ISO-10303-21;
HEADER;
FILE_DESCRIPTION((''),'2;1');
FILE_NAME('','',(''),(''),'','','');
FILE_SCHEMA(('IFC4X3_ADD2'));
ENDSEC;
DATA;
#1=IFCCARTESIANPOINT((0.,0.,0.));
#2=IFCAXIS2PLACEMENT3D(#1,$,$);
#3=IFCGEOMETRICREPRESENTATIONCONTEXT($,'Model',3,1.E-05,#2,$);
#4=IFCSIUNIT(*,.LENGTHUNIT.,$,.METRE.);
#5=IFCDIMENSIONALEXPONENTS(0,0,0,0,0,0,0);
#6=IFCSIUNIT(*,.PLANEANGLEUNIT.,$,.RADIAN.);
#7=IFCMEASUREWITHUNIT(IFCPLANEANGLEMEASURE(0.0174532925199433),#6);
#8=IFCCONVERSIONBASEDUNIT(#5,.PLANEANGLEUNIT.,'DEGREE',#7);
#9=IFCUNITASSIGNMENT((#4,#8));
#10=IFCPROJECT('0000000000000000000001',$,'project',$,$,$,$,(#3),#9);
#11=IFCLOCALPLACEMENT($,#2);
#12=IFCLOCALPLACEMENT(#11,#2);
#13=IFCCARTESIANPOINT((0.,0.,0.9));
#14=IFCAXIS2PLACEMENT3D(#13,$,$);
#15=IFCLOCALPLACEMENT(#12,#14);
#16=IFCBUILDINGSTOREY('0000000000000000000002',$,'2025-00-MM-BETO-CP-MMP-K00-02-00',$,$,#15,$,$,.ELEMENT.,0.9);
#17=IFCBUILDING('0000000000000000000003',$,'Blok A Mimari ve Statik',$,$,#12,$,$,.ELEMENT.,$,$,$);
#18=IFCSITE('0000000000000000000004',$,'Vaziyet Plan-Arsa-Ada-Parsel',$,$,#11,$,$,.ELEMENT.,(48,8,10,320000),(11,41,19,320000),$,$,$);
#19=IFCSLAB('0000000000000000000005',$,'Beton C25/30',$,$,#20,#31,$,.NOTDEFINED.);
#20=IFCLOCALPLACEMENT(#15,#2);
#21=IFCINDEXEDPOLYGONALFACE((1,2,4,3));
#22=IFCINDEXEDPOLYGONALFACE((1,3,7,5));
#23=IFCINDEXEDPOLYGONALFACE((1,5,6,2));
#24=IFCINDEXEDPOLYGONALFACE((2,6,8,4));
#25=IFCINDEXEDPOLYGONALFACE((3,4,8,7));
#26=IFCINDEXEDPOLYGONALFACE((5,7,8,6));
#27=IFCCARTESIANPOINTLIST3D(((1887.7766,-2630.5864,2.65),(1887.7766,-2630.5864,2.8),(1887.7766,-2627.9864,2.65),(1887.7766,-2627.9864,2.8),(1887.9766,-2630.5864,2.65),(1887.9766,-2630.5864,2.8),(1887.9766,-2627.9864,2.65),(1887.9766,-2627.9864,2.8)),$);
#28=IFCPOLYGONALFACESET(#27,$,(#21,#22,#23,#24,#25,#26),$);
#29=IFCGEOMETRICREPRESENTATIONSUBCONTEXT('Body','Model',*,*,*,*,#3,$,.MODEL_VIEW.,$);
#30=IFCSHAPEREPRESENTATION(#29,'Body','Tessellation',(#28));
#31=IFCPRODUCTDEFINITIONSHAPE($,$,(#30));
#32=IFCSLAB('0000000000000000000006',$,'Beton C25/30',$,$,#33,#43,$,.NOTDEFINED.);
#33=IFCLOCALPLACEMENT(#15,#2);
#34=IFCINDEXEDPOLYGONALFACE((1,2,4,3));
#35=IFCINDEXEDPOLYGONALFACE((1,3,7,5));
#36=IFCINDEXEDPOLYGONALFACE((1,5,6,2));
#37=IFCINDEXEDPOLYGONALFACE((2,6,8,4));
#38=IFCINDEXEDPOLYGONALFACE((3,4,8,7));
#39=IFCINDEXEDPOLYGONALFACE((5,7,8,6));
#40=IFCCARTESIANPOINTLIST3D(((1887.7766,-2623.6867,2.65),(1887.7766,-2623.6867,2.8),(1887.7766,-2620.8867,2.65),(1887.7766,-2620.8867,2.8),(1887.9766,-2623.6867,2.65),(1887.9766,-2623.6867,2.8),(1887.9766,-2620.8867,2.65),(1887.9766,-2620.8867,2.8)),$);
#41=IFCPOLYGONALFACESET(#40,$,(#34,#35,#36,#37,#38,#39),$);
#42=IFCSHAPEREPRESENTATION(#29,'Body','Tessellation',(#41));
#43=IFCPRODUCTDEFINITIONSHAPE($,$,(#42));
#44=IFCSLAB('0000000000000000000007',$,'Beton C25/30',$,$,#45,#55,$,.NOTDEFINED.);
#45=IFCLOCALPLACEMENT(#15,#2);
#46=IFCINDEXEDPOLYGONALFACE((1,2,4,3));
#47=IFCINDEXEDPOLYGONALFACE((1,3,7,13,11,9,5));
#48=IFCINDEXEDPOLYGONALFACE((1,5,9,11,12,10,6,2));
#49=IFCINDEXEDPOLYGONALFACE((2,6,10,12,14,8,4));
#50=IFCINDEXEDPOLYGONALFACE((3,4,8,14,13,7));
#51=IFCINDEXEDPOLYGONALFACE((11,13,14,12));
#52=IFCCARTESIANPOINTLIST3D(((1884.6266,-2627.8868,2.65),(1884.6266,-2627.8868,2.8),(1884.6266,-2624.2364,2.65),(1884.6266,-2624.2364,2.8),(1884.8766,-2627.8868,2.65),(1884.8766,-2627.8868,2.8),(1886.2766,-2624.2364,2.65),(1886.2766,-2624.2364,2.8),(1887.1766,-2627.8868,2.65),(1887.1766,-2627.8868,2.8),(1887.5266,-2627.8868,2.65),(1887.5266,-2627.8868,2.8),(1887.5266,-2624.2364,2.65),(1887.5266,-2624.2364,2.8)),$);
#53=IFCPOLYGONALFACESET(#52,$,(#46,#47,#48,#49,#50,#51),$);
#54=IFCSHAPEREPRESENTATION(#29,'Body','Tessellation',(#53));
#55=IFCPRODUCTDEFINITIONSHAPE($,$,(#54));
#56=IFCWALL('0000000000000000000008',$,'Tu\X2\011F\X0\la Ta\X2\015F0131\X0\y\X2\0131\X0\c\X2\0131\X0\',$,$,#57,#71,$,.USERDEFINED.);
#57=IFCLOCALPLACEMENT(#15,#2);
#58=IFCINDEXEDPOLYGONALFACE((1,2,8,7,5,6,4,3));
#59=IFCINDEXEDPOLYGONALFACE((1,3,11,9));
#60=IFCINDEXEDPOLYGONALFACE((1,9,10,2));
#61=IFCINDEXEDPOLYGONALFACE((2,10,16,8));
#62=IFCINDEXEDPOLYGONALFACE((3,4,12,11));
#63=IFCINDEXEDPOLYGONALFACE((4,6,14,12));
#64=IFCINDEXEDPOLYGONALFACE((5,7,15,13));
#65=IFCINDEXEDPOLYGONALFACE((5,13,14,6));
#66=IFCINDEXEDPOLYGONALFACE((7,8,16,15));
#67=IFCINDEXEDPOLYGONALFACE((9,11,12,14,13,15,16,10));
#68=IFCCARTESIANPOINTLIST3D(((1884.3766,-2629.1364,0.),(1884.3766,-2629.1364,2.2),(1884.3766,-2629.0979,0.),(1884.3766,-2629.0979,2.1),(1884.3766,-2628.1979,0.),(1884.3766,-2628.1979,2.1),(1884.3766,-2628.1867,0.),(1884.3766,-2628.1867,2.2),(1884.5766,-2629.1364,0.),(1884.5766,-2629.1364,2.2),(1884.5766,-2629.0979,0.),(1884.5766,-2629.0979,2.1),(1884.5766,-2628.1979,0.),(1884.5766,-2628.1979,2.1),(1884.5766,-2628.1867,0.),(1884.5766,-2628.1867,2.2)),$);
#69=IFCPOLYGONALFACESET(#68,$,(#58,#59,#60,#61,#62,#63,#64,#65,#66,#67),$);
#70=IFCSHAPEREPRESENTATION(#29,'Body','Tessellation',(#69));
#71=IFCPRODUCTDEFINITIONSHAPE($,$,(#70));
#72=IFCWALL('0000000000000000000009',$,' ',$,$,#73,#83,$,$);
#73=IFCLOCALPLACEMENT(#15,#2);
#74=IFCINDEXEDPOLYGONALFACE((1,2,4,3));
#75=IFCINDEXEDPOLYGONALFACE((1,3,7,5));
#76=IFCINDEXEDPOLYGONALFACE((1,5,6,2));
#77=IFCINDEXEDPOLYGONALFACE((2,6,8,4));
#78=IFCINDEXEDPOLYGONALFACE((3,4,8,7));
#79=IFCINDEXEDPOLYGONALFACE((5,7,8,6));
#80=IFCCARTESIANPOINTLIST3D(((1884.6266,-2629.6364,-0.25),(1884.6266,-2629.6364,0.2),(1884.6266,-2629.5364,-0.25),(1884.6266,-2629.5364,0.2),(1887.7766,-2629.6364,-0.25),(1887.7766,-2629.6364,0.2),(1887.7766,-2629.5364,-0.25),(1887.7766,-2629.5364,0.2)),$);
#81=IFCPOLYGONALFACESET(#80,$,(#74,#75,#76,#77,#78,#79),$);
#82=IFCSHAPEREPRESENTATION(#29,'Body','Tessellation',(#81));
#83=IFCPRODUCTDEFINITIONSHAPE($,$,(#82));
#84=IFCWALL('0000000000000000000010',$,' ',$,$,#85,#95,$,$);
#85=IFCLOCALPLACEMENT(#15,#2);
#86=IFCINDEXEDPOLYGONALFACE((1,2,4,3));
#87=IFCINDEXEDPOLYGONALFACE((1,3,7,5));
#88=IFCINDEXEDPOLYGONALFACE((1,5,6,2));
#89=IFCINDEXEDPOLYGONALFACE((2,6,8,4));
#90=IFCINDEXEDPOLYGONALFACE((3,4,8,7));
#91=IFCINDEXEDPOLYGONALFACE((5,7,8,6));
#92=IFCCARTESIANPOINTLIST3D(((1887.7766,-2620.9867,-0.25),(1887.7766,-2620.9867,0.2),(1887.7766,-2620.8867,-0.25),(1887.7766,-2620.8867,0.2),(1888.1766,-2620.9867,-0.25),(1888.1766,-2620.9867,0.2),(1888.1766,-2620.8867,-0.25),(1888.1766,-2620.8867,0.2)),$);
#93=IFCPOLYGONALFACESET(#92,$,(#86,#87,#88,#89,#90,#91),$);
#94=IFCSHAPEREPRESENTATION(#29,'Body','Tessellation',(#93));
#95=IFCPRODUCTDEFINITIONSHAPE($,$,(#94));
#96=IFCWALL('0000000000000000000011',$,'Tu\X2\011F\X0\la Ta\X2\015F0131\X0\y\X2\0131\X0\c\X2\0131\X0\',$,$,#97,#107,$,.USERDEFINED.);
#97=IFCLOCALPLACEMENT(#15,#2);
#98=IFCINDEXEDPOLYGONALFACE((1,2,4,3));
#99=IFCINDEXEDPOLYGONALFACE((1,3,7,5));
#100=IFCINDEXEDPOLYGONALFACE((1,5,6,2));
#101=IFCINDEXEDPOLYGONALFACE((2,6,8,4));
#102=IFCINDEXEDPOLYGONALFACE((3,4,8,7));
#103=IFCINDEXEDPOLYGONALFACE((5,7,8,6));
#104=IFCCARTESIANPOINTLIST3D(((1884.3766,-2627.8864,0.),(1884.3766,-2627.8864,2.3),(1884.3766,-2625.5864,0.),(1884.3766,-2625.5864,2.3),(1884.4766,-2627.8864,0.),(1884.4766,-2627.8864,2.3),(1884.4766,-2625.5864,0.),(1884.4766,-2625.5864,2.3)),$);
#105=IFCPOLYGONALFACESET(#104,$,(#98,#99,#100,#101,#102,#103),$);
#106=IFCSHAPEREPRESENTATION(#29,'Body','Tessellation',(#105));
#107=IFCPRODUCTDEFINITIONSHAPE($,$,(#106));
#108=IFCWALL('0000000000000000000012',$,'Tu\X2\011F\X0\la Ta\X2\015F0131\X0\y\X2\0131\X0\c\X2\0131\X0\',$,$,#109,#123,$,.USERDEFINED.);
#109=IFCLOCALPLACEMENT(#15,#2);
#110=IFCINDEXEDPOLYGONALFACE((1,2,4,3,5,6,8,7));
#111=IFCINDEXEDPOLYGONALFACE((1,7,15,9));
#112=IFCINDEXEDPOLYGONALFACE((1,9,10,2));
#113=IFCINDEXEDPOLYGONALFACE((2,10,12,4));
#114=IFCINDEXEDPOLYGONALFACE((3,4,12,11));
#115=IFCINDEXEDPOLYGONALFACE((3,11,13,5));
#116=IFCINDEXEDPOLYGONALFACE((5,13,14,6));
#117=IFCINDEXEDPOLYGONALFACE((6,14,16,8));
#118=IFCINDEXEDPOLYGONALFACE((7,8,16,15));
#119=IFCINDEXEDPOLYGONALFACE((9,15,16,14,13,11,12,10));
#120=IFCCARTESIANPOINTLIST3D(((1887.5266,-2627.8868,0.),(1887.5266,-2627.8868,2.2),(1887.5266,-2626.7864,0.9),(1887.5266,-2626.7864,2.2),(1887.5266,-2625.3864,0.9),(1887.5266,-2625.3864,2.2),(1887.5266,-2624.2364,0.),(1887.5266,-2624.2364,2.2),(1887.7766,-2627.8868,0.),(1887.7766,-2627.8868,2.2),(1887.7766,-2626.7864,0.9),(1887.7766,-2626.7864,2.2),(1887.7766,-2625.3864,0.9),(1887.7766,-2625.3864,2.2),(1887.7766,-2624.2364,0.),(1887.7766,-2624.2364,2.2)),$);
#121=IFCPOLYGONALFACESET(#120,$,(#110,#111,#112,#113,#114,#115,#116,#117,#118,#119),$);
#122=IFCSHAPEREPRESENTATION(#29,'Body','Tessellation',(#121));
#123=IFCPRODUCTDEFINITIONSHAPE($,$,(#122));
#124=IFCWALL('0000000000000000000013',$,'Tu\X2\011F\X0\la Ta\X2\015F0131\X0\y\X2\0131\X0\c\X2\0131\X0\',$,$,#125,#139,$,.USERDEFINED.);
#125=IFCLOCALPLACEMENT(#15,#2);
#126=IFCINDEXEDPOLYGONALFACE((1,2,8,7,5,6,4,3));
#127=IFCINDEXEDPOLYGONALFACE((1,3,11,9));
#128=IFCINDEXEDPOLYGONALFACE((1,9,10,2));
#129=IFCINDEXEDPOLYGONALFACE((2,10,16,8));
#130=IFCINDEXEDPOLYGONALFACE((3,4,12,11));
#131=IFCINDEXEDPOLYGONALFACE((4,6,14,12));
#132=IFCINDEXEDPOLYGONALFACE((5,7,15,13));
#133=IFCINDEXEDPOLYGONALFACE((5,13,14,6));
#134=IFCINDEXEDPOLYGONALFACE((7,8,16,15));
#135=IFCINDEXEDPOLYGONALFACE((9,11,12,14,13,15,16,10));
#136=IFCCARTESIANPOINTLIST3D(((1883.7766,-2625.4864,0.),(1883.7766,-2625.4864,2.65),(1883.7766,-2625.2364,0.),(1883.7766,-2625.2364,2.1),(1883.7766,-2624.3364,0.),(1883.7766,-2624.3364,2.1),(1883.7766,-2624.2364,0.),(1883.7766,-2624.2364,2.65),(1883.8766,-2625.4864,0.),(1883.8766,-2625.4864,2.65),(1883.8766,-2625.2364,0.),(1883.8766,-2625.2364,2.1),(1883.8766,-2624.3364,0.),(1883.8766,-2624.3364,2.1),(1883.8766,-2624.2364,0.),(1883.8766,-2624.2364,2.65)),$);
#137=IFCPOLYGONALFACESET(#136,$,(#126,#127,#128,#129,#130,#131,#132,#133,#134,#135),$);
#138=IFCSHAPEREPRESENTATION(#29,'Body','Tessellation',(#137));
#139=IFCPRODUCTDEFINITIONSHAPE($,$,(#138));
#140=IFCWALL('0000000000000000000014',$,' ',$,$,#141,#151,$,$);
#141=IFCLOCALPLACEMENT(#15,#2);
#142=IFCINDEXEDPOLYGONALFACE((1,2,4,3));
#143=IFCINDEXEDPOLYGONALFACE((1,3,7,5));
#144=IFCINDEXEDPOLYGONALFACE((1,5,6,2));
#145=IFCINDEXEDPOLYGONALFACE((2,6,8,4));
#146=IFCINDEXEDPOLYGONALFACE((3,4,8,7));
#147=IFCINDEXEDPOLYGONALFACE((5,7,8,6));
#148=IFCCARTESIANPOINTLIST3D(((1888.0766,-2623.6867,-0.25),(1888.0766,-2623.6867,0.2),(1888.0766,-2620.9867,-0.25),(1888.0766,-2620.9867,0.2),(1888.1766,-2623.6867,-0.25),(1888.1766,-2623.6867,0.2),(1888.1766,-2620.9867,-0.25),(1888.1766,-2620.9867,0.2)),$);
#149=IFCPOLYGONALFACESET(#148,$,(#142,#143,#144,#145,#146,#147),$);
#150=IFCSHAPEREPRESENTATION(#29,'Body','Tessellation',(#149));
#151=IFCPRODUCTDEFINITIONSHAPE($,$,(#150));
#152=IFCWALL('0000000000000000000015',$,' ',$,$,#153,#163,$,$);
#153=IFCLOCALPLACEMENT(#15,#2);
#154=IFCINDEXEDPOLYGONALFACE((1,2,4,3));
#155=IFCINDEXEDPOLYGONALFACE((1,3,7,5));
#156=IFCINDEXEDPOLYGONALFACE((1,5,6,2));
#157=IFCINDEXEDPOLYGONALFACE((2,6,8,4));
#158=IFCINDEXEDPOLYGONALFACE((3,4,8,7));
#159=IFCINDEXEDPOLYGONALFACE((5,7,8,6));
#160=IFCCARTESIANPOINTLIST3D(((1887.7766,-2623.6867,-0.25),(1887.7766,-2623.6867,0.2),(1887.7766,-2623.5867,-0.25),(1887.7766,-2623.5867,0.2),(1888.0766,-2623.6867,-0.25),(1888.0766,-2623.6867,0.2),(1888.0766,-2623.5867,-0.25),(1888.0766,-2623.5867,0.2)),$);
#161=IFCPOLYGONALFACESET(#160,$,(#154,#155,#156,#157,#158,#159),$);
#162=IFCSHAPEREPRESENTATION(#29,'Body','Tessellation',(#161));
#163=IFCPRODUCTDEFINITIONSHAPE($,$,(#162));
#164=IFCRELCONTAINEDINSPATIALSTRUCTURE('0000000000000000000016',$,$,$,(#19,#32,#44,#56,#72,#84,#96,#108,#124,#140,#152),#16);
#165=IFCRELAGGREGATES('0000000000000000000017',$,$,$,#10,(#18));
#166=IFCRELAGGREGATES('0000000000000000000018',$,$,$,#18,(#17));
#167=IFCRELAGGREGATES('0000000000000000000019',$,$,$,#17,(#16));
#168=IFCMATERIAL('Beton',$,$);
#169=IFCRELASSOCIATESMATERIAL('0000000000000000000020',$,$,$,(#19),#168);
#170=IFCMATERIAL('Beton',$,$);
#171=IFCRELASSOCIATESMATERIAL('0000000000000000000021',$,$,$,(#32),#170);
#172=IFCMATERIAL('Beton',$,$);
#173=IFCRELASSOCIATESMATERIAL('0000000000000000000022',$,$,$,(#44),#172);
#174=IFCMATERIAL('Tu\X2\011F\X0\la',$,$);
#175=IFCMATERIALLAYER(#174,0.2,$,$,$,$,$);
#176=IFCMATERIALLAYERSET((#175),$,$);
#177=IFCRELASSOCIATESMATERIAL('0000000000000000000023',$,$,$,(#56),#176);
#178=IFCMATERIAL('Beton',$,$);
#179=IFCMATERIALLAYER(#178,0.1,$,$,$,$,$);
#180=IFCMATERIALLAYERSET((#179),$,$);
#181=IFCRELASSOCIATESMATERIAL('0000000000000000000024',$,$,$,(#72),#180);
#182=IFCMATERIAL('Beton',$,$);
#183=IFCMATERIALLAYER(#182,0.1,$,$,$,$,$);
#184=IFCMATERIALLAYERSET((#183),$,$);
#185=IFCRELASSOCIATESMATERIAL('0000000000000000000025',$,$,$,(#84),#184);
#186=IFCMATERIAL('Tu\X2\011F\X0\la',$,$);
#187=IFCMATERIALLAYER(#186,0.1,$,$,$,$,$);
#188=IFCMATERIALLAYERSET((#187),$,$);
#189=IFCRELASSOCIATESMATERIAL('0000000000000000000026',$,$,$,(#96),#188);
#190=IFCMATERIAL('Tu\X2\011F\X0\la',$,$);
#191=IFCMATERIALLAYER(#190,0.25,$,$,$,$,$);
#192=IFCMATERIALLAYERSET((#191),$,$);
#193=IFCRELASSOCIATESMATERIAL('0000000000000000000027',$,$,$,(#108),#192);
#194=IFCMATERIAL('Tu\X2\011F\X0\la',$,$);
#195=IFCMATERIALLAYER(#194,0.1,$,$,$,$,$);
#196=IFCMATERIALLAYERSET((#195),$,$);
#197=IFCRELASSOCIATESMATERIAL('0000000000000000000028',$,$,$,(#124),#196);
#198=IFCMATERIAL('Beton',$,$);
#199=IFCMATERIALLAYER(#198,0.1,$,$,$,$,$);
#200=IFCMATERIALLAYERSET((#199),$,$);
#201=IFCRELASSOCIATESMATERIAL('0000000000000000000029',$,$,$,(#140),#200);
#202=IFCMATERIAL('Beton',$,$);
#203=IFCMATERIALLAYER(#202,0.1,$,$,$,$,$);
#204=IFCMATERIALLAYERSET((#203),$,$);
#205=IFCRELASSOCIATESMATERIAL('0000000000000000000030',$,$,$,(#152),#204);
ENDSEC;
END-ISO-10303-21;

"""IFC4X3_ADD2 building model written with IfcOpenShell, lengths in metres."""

from ifc_helpers import new_model, entity, si_unit, converted_unit, frame, frame_2d, origin, origin_with_axes, place, context, subcontext, project, spatial, polyline, rectangle, outline, extrude, material, layer, layer_set, layer_usage, element, save


model = new_model("IFC4X3_ADD2")

# Units and contexts
model_context = context("Model", 3, precision=1e-05, world=origin())
body_context = subcontext(model_context, "Body", "Model", "MODEL_VIEW")
ifc_project = project(units=[si_unit("LENGTHUNIT", "METRE"), converted_unit("PLANEANGLEUNIT", "DEGREE", entity("IfcPlaneAngleMeasure", 0.0174532925199433), si_unit("PLANEANGLEUNIT", "RADIAN"), dimensions=[0, 0, 0, 0, 0, 0, 0])], contexts=[model_context])

# Site, building, storey
site_placement = place(None, origin())
site = spatial("IfcSite", under=ifc_project, at=site_placement, Name="Vaziyet Plan-Arsa-Ada-Parsel", CompositionType="ELEMENT", RefLatitude=(48, 8, 10, 320000), RefLongitude=(11, 41, 19, 320000))
building_placement = place(site_placement, origin())
building = spatial("IfcBuilding", under=site, at=building_placement, Name="Blok A Mimari ve Statik", CompositionType="ELEMENT")
storey_placement = place(building_placement, frame((0.0, 0.0, 0.9)))
storey = spatial("IfcBuildingStorey", under=building, at=storey_placement, Name="2025-00-MM-BETO-CP-MMP-K00-02-00", CompositionType="ELEMENT", Elevation=0.9)

# Slabs
ifc_material_1 = material(Name="Beton")
slab_1_placement = place(storey_placement, frame((1887.7766, -2630.5864, 2.65)))
element("IfcSlab", 1, at=slab_1_placement, inside=storey, material=ifc_material_1, Name="Beton C25/30", PredefinedType="NOTDEFINED", context=body_context, shape_type="SweptSolid", body=[
    extrude(rectangle(XDim=2.6, YDim=0.2, at=frame_2d((-0.1, 1.3), x_axis=(0.0, 1.0))), frame((0.2, 0.0, 0.0), z_axis=(0.0, 0.0, 1.0), x_axis=(1.0, 0.0, 0.0)), (0.0, 0.0, 1.0), 0.15),
])
ifc_material_2 = material(Name="Beton")
slab_2_placement = place(storey_placement, frame((1887.7766, -2623.6867, 2.65)))
element("IfcSlab", 2, at=slab_2_placement, inside=storey, material=ifc_material_2, Name="Beton C25/30", PredefinedType="NOTDEFINED", context=body_context, shape_type="SweptSolid", body=[
    extrude(rectangle(XDim=2.8, YDim=0.2, at=frame_2d((-0.1, 1.4), x_axis=(0.0, 1.0))), frame((0.2, 0.0, 0.0), z_axis=(0.0, 0.0, 1.0), x_axis=(1.0, 0.0, 0.0)), (0.0, 0.0, 1.0), 0.15),
])
ifc_material_3 = material(Name="Beton")
slab_3_placement = place(storey_placement, frame((1884.6266, -2627.8868, 2.65)))
element("IfcSlab", 3, at=slab_3_placement, inside=storey, material=ifc_material_3, Name="Beton C25/30", PredefinedType="NOTDEFINED", context=body_context, shape_type="SweptSolid", body=[
    extrude(outline(polyline([(0.0, 3.6503), (0.0, 0.0), (0.25, 0.0), (2.55, 0.0), (2.9, 0.0), (2.9, 3.6503), (1.65, 3.6503), (0.0, 3.6503)])), origin_with_axes(), (0.0, 0.0, 1.0), 0.15),
])

# Wall, opening
ifc_material_4 = material(Name="Tuğla")
ifc_layer_1 = layer(ifc_material_4, 0.2)
ifc_layer_set_1 = layer_set([ifc_layer_1])
ifc_layer_usage_1 = layer_usage(ifc_layer_set_1, "AXIS2", "POSITIVE", 0.0)
wall_1_placement = place(storey_placement, frame((1884.3766, -2628.1867, 0.0), z_axis=(0.0, 0.0, 1.0), x_axis=(0.0, -1.0, 0.0)))
wall_1 = element("IfcWall", 4, at=wall_1_placement, inside=storey, material=ifc_layer_usage_1, Name="Tuğla Taşıyıcı", PredefinedType="USERDEFINED", context=body_context, shape_type="SweptSolid", body=[
    extrude(rectangle(XDim=0.9497, YDim=0.2, at=frame_2d((0.4748, 0.1), x_axis=(1.0, 0.0))), origin_with_axes(), (0.0, 0.0, 1.0), 2.2),
])
opening_1_placement = place(wall_1_placement, frame((0.0111, 0.0, 0.0), z_axis=(0.0, 1.0, 0.0), x_axis=(0.0, 0.0, 1.0)))
element("IfcOpeningElement", 5, at=opening_1_placement, cuts=wall_1, PredefinedType="OPENING", context=body_context, shape_type="SweptSolid", body=[
    extrude(outline(polyline([(2.1, 0.9), (2.1, 0.0), (0.0, 0.0), (0.0, 0.9), (2.1, 0.9)])), origin_with_axes(), (0.0, 0.0, 1.0), 0.2),
])

# Walls
ifc_material_5 = material(Name="Beton")
ifc_layer_2 = layer(ifc_material_5, 0.1)
ifc_layer_set_2 = layer_set([ifc_layer_2])
ifc_layer_usage_2 = layer_usage(ifc_layer_set_2, "AXIS2", "POSITIVE", 0.0)
wall_2_placement = place(storey_placement, frame((1884.6266, -2629.6364, -0.25)))
element("IfcWall", 6, at=wall_2_placement, inside=storey, material=ifc_layer_usage_2, Name=" ", context=body_context, shape_type="SweptSolid", body=[
    extrude(rectangle(XDim=3.15, YDim=0.1, at=frame_2d((1.575, 0.05), x_axis=(1.0, 0.0))), origin_with_axes(), (0.0, 0.0, 1.0), 0.45),
])
ifc_material_6 = material(Name="Beton")
ifc_layer_3 = layer(ifc_material_6, 0.1)
ifc_layer_set_3 = layer_set([ifc_layer_3])
ifc_layer_usage_3 = layer_usage(ifc_layer_set_3, "AXIS2", "POSITIVE", 0.0)
wall_3_placement = place(storey_placement, frame((1888.1766, -2620.8867, -0.25), z_axis=(0.0, 0.0, 1.0), x_axis=(-1.0, 0.0, 0.0)))
element("IfcWall", 7, at=wall_3_placement, inside=storey, material=ifc_layer_usage_3, Name=" ", context=body_context, shape_type="SweptSolid", body=[
    extrude(rectangle(XDim=0.4, YDim=0.1, at=frame_2d((0.2, 0.05), x_axis=(1.0, 0.0))), origin_with_axes(), (0.0, 0.0, 1.0), 0.45),
])
ifc_material_7 = material(Name="Tuğla")
ifc_layer_4 = layer(ifc_material_7, 0.1)
ifc_layer_set_4 = layer_set([ifc_layer_4])
ifc_layer_usage_4 = layer_usage(ifc_layer_set_4, "AXIS2", "POSITIVE", 0.0)
wall_4_placement = place(storey_placement, frame((1884.4766, -2627.8864, 0.0), z_axis=(0.0, 0.0, 1.0), x_axis=(0.0, 1.0, 0.0)))
element("IfcWall", 8, at=wall_4_placement, inside=storey, material=ifc_layer_usage_4, Name="Tuğla Taşıyıcı", PredefinedType="USERDEFINED", context=body_context, shape_type="SweptSolid", body=[
    extrude(rectangle(XDim=2.3, YDim=0.1, at=frame_2d((1.15, 0.05), x_axis=(1.0, 0.0))), origin_with_axes(), (0.0, 0.0, 1.0), 2.3),
])

# Walls, openings
ifc_material_8 = material(Name="Tuğla")
ifc_layer_5 = layer(ifc_material_8, 0.25)
ifc_layer_set_5 = layer_set([ifc_layer_5])
ifc_layer_usage_5 = layer_usage(ifc_layer_set_5, "AXIS2", "POSITIVE", 0.0)
wall_5_placement = place(storey_placement, frame((1887.7766, -2627.8868, 0.0), z_axis=(0.0, 0.0, 1.0), x_axis=(0.0, 1.0, 0.0)))
wall_5 = element("IfcWall", 9, at=wall_5_placement, inside=storey, material=ifc_layer_usage_5, Name="Tuğla Taşıyıcı", PredefinedType="USERDEFINED", context=body_context, shape_type="SweptSolid", body=[
    extrude(rectangle(XDim=3.6503, YDim=0.25, at=frame_2d((1.8252, 0.125), x_axis=(1.0, 0.0))), origin_with_axes(), (0.0, 0.0, 1.0), 2.2),
])
opening_2_placement = place(wall_5_placement, frame((1.1003, 0.0, 0.9), z_axis=(0.0, 1.0, 0.0), x_axis=(0.0, 0.0, 1.0)))
element("IfcOpeningElement", 10, at=opening_2_placement, cuts=wall_5, PredefinedType="OPENING", context=body_context, shape_type="SweptSolid", body=[
    extrude(outline(polyline([(1.35, 1.4), (1.35, 0.0), (0.0, 0.0), (0.0, 1.4), (1.35, 1.4)])), origin_with_axes(), (0.0, 0.0, 1.0), 0.25),
])
ifc_material_9 = material(Name="Tuğla")
ifc_layer_6 = layer(ifc_material_9, 0.1)
ifc_layer_set_6 = layer_set([ifc_layer_6])
ifc_layer_usage_6 = layer_usage(ifc_layer_set_6, "AXIS2", "POSITIVE", 0.0)
wall_6_placement = place(storey_placement, frame((1883.7766, -2624.2364, 0.0), z_axis=(0.0, 0.0, 1.0), x_axis=(0.0, -1.0, 0.0)))
wall_6 = element("IfcWall", 11, at=wall_6_placement, inside=storey, material=ifc_layer_usage_6, Name="Tuğla Taşıyıcı", PredefinedType="USERDEFINED", context=body_context, shape_type="SweptSolid", body=[
    extrude(rectangle(XDim=1.25, YDim=0.1, at=frame_2d((0.625, 0.05), x_axis=(1.0, 0.0))), origin_with_axes(), (0.0, 0.0, 1.0), 2.65),
])
opening_3_placement = place(wall_6_placement, frame((1.0, 0.1, 0.0), z_axis=(0.0, -1.0, 0.0), x_axis=(0.0, 0.0, 1.0)))
element("IfcOpeningElement", 12, at=opening_3_placement, cuts=wall_6, PredefinedType="OPENING", context=body_context, shape_type="SweptSolid", body=[
    extrude(outline(polyline([(2.1, 0.9), (2.1, 0.0), (0.0, 0.0), (0.0, 0.9), (2.1, 0.9)])), origin_with_axes(), (0.0, 0.0, 1.0), 0.1),
])

# Walls
ifc_material_10 = material(Name="Beton")
ifc_layer_7 = layer(ifc_material_10, 0.1)
ifc_layer_set_7 = layer_set([ifc_layer_7])
ifc_layer_usage_7 = layer_usage(ifc_layer_set_7, "AXIS2", "POSITIVE", 0.0)
wall_7_placement = place(storey_placement, frame((1888.1766, -2623.6867, -0.25), z_axis=(0.0, 0.0, 1.0), x_axis=(0.0, 1.0, 0.0)))
element("IfcWall", 13, at=wall_7_placement, inside=storey, material=ifc_layer_usage_7, Name=" ", context=body_context, shape_type="SweptSolid", body=[
    extrude(rectangle(XDim=2.7, YDim=0.1, at=frame_2d((1.35, 0.05), x_axis=(1.0, 0.0))), origin_with_axes(), (0.0, 0.0, 1.0), 0.45),
])
ifc_material_11 = material(Name="Beton")
ifc_layer_8 = layer(ifc_material_11, 0.1)
ifc_layer_set_8 = layer_set([ifc_layer_8])
ifc_layer_usage_8 = layer_usage(ifc_layer_set_8, "AXIS2", "POSITIVE", 0.0)
wall_8_placement = place(storey_placement, frame((1887.7766, -2623.6867, -0.25)))
element("IfcWall", 14, at=wall_8_placement, inside=storey, material=ifc_layer_usage_8, Name=" ", context=body_context, shape_type="SweptSolid", body=[
    extrude(rectangle(XDim=0.3, YDim=0.1, at=frame_2d((0.15, 0.05), x_axis=(1.0, 0.0))), origin_with_axes(), (0.0, 0.0, 1.0), 0.45),
])

save(model, "model.ifc")
